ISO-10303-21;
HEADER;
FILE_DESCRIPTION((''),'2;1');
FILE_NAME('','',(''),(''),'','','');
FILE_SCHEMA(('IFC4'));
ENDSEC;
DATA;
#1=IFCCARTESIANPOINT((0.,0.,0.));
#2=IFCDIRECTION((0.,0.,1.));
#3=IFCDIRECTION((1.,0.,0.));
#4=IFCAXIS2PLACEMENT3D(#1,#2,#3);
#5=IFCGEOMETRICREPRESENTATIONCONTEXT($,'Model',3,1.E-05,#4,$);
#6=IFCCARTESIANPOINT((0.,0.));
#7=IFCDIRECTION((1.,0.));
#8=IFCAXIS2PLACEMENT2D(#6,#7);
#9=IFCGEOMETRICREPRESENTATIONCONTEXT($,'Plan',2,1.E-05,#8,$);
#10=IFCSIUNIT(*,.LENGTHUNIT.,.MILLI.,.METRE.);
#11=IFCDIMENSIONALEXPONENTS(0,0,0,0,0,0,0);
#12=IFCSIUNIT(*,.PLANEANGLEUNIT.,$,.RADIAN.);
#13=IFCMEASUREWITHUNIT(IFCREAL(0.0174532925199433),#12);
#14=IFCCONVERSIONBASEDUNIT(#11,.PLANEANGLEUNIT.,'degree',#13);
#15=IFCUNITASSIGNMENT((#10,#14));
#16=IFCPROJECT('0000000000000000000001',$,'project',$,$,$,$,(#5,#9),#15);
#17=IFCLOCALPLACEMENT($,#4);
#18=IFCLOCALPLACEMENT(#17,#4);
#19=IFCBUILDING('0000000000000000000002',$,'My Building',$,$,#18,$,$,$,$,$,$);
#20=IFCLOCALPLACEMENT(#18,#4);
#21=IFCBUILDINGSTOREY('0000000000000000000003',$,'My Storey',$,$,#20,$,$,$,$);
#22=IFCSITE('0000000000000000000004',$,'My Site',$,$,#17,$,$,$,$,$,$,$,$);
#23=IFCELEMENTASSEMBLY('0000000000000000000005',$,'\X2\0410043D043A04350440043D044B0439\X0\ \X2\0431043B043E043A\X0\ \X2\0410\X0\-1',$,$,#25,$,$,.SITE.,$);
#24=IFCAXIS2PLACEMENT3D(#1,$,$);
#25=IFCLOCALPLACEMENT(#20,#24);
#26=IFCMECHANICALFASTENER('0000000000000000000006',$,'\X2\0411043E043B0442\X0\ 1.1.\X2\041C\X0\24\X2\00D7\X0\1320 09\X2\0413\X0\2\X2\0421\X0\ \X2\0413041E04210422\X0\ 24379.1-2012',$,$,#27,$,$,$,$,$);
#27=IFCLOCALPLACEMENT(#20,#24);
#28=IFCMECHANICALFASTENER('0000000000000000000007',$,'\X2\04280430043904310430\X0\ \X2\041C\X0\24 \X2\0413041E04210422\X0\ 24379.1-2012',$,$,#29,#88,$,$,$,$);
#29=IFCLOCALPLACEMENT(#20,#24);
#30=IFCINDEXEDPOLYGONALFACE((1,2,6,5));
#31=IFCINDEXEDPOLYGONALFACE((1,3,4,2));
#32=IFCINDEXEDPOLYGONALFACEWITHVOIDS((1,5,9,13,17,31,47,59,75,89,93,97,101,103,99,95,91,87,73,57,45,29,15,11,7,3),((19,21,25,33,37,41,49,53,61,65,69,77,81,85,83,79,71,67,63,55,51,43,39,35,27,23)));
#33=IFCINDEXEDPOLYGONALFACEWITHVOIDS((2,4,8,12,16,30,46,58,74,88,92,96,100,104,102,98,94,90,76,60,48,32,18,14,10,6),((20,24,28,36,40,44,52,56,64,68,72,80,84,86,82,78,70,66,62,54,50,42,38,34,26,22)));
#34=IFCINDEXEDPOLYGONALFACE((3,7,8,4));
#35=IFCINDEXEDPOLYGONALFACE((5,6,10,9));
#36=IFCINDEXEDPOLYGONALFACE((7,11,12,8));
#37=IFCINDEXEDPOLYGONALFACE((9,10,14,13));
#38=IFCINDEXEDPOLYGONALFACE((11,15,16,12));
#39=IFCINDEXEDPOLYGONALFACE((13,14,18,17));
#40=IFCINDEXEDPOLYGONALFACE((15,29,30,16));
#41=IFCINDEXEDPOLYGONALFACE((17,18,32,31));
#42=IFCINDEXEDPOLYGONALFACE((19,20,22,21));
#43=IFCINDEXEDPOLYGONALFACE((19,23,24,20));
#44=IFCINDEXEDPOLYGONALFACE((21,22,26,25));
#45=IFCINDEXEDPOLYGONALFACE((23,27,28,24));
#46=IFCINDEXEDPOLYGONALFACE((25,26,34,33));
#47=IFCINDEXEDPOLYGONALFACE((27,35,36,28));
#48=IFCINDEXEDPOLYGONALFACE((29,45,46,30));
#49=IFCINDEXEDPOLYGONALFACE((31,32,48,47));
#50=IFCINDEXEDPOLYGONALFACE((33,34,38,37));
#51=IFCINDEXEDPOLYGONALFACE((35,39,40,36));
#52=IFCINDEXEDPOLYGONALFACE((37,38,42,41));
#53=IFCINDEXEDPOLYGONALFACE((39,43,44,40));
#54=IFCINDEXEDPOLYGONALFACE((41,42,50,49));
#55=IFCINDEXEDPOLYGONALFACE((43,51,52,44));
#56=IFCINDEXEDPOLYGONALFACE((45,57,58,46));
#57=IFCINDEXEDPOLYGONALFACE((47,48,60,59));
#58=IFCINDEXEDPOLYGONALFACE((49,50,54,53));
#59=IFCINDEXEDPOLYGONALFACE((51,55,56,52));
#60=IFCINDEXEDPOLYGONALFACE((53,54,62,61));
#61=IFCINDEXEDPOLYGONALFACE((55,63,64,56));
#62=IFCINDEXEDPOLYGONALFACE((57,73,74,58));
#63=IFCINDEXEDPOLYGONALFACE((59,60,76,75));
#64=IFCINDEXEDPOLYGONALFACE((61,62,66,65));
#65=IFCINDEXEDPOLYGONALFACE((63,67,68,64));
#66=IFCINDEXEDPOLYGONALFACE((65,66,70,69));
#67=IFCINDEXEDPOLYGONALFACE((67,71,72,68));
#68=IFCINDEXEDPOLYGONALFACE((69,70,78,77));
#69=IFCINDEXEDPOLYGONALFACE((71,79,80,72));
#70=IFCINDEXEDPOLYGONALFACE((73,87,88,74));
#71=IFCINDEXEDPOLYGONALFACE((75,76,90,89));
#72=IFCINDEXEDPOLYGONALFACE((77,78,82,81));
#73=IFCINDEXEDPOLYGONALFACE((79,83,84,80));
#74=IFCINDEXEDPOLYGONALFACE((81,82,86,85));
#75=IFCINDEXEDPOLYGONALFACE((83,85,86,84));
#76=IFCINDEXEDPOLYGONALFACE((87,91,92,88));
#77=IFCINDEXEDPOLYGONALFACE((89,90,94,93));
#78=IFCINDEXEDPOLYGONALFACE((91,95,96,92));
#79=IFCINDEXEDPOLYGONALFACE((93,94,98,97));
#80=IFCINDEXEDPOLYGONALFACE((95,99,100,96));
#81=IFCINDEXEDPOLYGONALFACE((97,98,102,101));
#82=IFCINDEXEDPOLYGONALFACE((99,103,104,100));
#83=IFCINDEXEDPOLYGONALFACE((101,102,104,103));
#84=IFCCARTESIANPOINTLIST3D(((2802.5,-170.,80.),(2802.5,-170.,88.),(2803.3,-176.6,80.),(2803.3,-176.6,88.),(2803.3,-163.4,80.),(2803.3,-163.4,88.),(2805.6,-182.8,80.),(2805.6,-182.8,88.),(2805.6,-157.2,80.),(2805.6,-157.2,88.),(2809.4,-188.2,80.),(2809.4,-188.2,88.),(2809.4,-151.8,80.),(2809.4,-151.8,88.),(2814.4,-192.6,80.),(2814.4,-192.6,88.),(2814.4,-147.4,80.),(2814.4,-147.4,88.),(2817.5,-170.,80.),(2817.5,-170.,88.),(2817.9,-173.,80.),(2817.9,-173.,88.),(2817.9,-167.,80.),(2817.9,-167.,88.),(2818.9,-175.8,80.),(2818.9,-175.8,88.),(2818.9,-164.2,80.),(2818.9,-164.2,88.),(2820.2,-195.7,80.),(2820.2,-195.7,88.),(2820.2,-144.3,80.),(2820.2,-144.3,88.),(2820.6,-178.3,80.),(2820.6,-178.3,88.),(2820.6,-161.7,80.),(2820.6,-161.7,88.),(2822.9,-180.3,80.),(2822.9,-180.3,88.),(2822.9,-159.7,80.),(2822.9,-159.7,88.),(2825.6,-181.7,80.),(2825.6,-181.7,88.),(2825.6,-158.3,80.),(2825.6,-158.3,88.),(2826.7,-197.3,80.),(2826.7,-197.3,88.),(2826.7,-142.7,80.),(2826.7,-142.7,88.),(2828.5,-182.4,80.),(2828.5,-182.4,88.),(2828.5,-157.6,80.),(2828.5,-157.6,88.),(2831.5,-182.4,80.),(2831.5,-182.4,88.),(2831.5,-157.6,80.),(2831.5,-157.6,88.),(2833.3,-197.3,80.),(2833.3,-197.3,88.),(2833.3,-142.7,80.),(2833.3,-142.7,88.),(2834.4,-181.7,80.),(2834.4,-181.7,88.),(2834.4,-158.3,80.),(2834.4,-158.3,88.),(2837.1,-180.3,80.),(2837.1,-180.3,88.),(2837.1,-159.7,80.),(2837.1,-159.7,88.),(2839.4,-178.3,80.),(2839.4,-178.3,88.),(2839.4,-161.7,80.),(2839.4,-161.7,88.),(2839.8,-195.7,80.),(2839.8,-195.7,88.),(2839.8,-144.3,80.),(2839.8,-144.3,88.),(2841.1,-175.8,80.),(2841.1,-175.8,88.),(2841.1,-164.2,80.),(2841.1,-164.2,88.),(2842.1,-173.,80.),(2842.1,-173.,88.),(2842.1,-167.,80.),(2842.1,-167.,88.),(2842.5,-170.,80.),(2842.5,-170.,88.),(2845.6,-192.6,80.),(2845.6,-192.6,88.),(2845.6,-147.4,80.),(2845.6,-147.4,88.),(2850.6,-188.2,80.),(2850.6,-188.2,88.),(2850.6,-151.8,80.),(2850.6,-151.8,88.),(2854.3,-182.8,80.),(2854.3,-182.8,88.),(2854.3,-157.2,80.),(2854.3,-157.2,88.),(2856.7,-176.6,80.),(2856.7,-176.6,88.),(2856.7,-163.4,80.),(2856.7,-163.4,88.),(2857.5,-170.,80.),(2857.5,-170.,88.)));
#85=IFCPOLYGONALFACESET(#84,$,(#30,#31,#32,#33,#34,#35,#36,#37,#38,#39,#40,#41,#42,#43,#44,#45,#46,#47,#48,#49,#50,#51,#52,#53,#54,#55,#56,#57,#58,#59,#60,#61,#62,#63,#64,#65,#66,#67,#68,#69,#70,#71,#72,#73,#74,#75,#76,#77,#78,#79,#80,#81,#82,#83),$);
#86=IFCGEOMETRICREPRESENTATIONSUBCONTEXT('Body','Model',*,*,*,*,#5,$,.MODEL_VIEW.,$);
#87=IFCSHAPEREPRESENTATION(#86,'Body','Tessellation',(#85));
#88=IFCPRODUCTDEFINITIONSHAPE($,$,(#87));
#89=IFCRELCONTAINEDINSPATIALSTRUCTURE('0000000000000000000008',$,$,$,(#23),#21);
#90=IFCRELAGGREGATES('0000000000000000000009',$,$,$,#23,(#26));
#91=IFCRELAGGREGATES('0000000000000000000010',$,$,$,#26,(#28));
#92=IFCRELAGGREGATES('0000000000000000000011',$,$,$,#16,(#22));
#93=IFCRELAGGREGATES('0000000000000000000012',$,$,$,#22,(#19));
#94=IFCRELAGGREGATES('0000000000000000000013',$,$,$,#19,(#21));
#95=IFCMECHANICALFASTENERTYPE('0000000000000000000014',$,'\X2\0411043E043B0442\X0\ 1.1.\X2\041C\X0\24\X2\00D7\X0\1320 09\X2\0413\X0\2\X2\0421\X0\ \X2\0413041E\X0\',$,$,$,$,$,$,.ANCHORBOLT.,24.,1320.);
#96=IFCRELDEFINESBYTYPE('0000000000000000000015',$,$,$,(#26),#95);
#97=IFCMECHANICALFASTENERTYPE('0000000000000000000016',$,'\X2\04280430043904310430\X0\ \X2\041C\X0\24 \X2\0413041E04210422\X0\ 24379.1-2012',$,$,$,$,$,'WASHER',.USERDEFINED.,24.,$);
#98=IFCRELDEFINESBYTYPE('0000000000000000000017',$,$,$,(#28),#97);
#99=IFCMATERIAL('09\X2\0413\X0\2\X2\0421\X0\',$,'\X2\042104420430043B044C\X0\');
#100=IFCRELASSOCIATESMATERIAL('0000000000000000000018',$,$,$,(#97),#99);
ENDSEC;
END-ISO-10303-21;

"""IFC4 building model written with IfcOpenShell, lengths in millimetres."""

from ifc_helpers import new_model, entity, si_unit, converted_unit, frame, origin_with_axes, origin_2d_with_axis, place, context, subcontext, project, spatial, polyline, outline, extrude, source, transform, mapped, material, type_object, type_shapes, element, aggregate, save


model = new_model("IFC4")

# Units and contexts
model_context = context("Model", 3, precision=1e-05, world=origin_with_axes())
plan_context = context("Plan", 2, precision=1e-05, world=origin_2d_with_axis())
body_context = subcontext(model_context, "Body", "Model", "MODEL_VIEW")
ifc_project = project(units=[si_unit("LENGTHUNIT", "METRE", prefix="MILLI"), converted_unit("PLANEANGLEUNIT", "degree", entity("IfcReal", 0.0174532925199433), si_unit("PLANEANGLEUNIT", "RADIAN"), dimensions=[0, 0, 0, 0, 0, 0, 0])], contexts=[model_context, plan_context])

# Site, building, storey
site_placement = place(None, origin_with_axes())
site = spatial("IfcSite", under=ifc_project, at=site_placement, Name="My Site")
building_placement = place(site_placement, origin_with_axes())
building = spatial("IfcBuilding", under=site, at=building_placement, Name="My Building")
storey_placement = place(building_placement, origin_with_axes())
storey = spatial("IfcBuildingStorey", under=building, at=storey_placement, Name="My Storey")

# Element assembly, mechanical fastener
ifc_material_1 = material(Name="09Г2С", Category="Сталь")
mechanical_fastener_type_1 = type_object("IfcMechanicalFastenerType", Name="Болт 1.1.М24×1320 09Г2С ГО", NominalDiameter=24.0, NominalLength=1320.0, PredefinedType="ANCHORBOLT")
assembly_1_placement = place(storey_placement, frame((3000.0, 0.0, 0.0), z_axis=(0.0, 0.0, 1.0), x_axis=(1.0, 0.0, 0.0)))
assembly_1 = element("IfcElementAssembly", 1, at=assembly_1_placement, inside=storey, Name="Анкерный блок А-1", AssemblyPlace="SITE")
mechanical_fastener_1_placement = place(assembly_1_placement, frame((-170.0, -170.0, 0.0), z_axis=(0.0, 0.0, 1.0), x_axis=(1.0, 0.0, 0.0)))
mechanical_fastener_1 = element("IfcMechanicalFastener", 2, at=mechanical_fastener_1_placement, type_object=mechanical_fastener_type_1, Name="Болт 1.1.М24×1320 09Г2С ГОСТ 24379.1-2012")
aggregate(assembly_1, [mechanical_fastener_1])

# Mechanical fastener
mechanical_fastener_type_2 = type_object("IfcMechanicalFastenerType", Name="Шайба М24 ГОСТ 24379.1-2012", ElementType="WASHER", NominalDiameter=24.0, PredefinedType="USERDEFINED", material=ifc_material_1)
shared_shape_1 = source(origin_with_axes(), body_context, "Body", "SweptSolid", [
    extrude(outline(polyline([(27.5, 0.0), (26.7, 6.6), (24.4, 12.8), (20.6, 18.2), (15.6, 22.6), (9.8, 25.7), (3.3, 27.3), (-3.3, 27.3), (-9.8, 25.7), (-15.6, 22.6), (-20.6, 18.2), (-24.4, 12.8), (-26.7, 6.6), (-27.5, 0.0), (-26.7, -6.6), (-24.4, -12.8), (-20.6, -18.2), (-15.6, -22.6), (-9.8, -25.7), (-3.3, -27.3), (3.3, -27.3), (9.8, -25.7), (15.6, -22.6), (20.6, -18.2), (24.4, -12.8), (26.7, -6.6), (27.5, 0.0)]), holes=[polyline([(-4.4, -11.7), (-7.1, -10.3), (-9.4, -8.3), (-11.1, -5.8), (-12.1, -3.0), (-12.5, 0.0), (-12.1, 3.0), (-11.1, 5.8), (-9.4, 8.3), (-7.1, 10.3), (-4.4, 11.7), (-1.5, 12.4), (1.5, 12.4), (4.4, 11.7), (7.1, 10.3), (9.4, 8.3), (11.1, 5.8), (12.1, 3.0), (12.5, 0.0), (12.1, -3.0), (11.1, -5.8), (9.4, -8.3), (7.1, -10.3), (4.4, -11.7), (1.5, -12.4), (-1.5, -12.4), (-4.4, -11.7)])]), frame((0.0, 0.0, 0.0), z_axis=(0.0, 0.0, 1.0), x_axis=(0.120537, -0.992709, 0.0)), (0.0, 0.0, 1.0), 8.0),
])
type_shapes(mechanical_fastener_type_2, [shared_shape_1])
mechanical_fastener_2_placement = place(mechanical_fastener_1_placement, frame((0.0, 0.0, 80.0), z_axis=(0.0, 0.0, 1.0), x_axis=(1.0, 0.0, 0.0)))
mechanical_fastener_2 = element("IfcMechanicalFastener", 3, at=mechanical_fastener_2_placement, type_object=mechanical_fastener_type_2, Name="Шайба М24 ГОСТ 24379.1-2012", context=body_context, shape_type="MappedRepresentation", body=[
    mapped(shared_shape_1, transform((0.0, 0.0, 0.0), x_axis=(1.0, 0.0, 0.0), y_axis=(0.0, 1.0, 0.0), z_axis=(0.0, 0.0, 1.0), scale=1.0)),
])
aggregate(mechanical_fastener_1, [mechanical_fastener_2])

save(model, "model.ifc")
